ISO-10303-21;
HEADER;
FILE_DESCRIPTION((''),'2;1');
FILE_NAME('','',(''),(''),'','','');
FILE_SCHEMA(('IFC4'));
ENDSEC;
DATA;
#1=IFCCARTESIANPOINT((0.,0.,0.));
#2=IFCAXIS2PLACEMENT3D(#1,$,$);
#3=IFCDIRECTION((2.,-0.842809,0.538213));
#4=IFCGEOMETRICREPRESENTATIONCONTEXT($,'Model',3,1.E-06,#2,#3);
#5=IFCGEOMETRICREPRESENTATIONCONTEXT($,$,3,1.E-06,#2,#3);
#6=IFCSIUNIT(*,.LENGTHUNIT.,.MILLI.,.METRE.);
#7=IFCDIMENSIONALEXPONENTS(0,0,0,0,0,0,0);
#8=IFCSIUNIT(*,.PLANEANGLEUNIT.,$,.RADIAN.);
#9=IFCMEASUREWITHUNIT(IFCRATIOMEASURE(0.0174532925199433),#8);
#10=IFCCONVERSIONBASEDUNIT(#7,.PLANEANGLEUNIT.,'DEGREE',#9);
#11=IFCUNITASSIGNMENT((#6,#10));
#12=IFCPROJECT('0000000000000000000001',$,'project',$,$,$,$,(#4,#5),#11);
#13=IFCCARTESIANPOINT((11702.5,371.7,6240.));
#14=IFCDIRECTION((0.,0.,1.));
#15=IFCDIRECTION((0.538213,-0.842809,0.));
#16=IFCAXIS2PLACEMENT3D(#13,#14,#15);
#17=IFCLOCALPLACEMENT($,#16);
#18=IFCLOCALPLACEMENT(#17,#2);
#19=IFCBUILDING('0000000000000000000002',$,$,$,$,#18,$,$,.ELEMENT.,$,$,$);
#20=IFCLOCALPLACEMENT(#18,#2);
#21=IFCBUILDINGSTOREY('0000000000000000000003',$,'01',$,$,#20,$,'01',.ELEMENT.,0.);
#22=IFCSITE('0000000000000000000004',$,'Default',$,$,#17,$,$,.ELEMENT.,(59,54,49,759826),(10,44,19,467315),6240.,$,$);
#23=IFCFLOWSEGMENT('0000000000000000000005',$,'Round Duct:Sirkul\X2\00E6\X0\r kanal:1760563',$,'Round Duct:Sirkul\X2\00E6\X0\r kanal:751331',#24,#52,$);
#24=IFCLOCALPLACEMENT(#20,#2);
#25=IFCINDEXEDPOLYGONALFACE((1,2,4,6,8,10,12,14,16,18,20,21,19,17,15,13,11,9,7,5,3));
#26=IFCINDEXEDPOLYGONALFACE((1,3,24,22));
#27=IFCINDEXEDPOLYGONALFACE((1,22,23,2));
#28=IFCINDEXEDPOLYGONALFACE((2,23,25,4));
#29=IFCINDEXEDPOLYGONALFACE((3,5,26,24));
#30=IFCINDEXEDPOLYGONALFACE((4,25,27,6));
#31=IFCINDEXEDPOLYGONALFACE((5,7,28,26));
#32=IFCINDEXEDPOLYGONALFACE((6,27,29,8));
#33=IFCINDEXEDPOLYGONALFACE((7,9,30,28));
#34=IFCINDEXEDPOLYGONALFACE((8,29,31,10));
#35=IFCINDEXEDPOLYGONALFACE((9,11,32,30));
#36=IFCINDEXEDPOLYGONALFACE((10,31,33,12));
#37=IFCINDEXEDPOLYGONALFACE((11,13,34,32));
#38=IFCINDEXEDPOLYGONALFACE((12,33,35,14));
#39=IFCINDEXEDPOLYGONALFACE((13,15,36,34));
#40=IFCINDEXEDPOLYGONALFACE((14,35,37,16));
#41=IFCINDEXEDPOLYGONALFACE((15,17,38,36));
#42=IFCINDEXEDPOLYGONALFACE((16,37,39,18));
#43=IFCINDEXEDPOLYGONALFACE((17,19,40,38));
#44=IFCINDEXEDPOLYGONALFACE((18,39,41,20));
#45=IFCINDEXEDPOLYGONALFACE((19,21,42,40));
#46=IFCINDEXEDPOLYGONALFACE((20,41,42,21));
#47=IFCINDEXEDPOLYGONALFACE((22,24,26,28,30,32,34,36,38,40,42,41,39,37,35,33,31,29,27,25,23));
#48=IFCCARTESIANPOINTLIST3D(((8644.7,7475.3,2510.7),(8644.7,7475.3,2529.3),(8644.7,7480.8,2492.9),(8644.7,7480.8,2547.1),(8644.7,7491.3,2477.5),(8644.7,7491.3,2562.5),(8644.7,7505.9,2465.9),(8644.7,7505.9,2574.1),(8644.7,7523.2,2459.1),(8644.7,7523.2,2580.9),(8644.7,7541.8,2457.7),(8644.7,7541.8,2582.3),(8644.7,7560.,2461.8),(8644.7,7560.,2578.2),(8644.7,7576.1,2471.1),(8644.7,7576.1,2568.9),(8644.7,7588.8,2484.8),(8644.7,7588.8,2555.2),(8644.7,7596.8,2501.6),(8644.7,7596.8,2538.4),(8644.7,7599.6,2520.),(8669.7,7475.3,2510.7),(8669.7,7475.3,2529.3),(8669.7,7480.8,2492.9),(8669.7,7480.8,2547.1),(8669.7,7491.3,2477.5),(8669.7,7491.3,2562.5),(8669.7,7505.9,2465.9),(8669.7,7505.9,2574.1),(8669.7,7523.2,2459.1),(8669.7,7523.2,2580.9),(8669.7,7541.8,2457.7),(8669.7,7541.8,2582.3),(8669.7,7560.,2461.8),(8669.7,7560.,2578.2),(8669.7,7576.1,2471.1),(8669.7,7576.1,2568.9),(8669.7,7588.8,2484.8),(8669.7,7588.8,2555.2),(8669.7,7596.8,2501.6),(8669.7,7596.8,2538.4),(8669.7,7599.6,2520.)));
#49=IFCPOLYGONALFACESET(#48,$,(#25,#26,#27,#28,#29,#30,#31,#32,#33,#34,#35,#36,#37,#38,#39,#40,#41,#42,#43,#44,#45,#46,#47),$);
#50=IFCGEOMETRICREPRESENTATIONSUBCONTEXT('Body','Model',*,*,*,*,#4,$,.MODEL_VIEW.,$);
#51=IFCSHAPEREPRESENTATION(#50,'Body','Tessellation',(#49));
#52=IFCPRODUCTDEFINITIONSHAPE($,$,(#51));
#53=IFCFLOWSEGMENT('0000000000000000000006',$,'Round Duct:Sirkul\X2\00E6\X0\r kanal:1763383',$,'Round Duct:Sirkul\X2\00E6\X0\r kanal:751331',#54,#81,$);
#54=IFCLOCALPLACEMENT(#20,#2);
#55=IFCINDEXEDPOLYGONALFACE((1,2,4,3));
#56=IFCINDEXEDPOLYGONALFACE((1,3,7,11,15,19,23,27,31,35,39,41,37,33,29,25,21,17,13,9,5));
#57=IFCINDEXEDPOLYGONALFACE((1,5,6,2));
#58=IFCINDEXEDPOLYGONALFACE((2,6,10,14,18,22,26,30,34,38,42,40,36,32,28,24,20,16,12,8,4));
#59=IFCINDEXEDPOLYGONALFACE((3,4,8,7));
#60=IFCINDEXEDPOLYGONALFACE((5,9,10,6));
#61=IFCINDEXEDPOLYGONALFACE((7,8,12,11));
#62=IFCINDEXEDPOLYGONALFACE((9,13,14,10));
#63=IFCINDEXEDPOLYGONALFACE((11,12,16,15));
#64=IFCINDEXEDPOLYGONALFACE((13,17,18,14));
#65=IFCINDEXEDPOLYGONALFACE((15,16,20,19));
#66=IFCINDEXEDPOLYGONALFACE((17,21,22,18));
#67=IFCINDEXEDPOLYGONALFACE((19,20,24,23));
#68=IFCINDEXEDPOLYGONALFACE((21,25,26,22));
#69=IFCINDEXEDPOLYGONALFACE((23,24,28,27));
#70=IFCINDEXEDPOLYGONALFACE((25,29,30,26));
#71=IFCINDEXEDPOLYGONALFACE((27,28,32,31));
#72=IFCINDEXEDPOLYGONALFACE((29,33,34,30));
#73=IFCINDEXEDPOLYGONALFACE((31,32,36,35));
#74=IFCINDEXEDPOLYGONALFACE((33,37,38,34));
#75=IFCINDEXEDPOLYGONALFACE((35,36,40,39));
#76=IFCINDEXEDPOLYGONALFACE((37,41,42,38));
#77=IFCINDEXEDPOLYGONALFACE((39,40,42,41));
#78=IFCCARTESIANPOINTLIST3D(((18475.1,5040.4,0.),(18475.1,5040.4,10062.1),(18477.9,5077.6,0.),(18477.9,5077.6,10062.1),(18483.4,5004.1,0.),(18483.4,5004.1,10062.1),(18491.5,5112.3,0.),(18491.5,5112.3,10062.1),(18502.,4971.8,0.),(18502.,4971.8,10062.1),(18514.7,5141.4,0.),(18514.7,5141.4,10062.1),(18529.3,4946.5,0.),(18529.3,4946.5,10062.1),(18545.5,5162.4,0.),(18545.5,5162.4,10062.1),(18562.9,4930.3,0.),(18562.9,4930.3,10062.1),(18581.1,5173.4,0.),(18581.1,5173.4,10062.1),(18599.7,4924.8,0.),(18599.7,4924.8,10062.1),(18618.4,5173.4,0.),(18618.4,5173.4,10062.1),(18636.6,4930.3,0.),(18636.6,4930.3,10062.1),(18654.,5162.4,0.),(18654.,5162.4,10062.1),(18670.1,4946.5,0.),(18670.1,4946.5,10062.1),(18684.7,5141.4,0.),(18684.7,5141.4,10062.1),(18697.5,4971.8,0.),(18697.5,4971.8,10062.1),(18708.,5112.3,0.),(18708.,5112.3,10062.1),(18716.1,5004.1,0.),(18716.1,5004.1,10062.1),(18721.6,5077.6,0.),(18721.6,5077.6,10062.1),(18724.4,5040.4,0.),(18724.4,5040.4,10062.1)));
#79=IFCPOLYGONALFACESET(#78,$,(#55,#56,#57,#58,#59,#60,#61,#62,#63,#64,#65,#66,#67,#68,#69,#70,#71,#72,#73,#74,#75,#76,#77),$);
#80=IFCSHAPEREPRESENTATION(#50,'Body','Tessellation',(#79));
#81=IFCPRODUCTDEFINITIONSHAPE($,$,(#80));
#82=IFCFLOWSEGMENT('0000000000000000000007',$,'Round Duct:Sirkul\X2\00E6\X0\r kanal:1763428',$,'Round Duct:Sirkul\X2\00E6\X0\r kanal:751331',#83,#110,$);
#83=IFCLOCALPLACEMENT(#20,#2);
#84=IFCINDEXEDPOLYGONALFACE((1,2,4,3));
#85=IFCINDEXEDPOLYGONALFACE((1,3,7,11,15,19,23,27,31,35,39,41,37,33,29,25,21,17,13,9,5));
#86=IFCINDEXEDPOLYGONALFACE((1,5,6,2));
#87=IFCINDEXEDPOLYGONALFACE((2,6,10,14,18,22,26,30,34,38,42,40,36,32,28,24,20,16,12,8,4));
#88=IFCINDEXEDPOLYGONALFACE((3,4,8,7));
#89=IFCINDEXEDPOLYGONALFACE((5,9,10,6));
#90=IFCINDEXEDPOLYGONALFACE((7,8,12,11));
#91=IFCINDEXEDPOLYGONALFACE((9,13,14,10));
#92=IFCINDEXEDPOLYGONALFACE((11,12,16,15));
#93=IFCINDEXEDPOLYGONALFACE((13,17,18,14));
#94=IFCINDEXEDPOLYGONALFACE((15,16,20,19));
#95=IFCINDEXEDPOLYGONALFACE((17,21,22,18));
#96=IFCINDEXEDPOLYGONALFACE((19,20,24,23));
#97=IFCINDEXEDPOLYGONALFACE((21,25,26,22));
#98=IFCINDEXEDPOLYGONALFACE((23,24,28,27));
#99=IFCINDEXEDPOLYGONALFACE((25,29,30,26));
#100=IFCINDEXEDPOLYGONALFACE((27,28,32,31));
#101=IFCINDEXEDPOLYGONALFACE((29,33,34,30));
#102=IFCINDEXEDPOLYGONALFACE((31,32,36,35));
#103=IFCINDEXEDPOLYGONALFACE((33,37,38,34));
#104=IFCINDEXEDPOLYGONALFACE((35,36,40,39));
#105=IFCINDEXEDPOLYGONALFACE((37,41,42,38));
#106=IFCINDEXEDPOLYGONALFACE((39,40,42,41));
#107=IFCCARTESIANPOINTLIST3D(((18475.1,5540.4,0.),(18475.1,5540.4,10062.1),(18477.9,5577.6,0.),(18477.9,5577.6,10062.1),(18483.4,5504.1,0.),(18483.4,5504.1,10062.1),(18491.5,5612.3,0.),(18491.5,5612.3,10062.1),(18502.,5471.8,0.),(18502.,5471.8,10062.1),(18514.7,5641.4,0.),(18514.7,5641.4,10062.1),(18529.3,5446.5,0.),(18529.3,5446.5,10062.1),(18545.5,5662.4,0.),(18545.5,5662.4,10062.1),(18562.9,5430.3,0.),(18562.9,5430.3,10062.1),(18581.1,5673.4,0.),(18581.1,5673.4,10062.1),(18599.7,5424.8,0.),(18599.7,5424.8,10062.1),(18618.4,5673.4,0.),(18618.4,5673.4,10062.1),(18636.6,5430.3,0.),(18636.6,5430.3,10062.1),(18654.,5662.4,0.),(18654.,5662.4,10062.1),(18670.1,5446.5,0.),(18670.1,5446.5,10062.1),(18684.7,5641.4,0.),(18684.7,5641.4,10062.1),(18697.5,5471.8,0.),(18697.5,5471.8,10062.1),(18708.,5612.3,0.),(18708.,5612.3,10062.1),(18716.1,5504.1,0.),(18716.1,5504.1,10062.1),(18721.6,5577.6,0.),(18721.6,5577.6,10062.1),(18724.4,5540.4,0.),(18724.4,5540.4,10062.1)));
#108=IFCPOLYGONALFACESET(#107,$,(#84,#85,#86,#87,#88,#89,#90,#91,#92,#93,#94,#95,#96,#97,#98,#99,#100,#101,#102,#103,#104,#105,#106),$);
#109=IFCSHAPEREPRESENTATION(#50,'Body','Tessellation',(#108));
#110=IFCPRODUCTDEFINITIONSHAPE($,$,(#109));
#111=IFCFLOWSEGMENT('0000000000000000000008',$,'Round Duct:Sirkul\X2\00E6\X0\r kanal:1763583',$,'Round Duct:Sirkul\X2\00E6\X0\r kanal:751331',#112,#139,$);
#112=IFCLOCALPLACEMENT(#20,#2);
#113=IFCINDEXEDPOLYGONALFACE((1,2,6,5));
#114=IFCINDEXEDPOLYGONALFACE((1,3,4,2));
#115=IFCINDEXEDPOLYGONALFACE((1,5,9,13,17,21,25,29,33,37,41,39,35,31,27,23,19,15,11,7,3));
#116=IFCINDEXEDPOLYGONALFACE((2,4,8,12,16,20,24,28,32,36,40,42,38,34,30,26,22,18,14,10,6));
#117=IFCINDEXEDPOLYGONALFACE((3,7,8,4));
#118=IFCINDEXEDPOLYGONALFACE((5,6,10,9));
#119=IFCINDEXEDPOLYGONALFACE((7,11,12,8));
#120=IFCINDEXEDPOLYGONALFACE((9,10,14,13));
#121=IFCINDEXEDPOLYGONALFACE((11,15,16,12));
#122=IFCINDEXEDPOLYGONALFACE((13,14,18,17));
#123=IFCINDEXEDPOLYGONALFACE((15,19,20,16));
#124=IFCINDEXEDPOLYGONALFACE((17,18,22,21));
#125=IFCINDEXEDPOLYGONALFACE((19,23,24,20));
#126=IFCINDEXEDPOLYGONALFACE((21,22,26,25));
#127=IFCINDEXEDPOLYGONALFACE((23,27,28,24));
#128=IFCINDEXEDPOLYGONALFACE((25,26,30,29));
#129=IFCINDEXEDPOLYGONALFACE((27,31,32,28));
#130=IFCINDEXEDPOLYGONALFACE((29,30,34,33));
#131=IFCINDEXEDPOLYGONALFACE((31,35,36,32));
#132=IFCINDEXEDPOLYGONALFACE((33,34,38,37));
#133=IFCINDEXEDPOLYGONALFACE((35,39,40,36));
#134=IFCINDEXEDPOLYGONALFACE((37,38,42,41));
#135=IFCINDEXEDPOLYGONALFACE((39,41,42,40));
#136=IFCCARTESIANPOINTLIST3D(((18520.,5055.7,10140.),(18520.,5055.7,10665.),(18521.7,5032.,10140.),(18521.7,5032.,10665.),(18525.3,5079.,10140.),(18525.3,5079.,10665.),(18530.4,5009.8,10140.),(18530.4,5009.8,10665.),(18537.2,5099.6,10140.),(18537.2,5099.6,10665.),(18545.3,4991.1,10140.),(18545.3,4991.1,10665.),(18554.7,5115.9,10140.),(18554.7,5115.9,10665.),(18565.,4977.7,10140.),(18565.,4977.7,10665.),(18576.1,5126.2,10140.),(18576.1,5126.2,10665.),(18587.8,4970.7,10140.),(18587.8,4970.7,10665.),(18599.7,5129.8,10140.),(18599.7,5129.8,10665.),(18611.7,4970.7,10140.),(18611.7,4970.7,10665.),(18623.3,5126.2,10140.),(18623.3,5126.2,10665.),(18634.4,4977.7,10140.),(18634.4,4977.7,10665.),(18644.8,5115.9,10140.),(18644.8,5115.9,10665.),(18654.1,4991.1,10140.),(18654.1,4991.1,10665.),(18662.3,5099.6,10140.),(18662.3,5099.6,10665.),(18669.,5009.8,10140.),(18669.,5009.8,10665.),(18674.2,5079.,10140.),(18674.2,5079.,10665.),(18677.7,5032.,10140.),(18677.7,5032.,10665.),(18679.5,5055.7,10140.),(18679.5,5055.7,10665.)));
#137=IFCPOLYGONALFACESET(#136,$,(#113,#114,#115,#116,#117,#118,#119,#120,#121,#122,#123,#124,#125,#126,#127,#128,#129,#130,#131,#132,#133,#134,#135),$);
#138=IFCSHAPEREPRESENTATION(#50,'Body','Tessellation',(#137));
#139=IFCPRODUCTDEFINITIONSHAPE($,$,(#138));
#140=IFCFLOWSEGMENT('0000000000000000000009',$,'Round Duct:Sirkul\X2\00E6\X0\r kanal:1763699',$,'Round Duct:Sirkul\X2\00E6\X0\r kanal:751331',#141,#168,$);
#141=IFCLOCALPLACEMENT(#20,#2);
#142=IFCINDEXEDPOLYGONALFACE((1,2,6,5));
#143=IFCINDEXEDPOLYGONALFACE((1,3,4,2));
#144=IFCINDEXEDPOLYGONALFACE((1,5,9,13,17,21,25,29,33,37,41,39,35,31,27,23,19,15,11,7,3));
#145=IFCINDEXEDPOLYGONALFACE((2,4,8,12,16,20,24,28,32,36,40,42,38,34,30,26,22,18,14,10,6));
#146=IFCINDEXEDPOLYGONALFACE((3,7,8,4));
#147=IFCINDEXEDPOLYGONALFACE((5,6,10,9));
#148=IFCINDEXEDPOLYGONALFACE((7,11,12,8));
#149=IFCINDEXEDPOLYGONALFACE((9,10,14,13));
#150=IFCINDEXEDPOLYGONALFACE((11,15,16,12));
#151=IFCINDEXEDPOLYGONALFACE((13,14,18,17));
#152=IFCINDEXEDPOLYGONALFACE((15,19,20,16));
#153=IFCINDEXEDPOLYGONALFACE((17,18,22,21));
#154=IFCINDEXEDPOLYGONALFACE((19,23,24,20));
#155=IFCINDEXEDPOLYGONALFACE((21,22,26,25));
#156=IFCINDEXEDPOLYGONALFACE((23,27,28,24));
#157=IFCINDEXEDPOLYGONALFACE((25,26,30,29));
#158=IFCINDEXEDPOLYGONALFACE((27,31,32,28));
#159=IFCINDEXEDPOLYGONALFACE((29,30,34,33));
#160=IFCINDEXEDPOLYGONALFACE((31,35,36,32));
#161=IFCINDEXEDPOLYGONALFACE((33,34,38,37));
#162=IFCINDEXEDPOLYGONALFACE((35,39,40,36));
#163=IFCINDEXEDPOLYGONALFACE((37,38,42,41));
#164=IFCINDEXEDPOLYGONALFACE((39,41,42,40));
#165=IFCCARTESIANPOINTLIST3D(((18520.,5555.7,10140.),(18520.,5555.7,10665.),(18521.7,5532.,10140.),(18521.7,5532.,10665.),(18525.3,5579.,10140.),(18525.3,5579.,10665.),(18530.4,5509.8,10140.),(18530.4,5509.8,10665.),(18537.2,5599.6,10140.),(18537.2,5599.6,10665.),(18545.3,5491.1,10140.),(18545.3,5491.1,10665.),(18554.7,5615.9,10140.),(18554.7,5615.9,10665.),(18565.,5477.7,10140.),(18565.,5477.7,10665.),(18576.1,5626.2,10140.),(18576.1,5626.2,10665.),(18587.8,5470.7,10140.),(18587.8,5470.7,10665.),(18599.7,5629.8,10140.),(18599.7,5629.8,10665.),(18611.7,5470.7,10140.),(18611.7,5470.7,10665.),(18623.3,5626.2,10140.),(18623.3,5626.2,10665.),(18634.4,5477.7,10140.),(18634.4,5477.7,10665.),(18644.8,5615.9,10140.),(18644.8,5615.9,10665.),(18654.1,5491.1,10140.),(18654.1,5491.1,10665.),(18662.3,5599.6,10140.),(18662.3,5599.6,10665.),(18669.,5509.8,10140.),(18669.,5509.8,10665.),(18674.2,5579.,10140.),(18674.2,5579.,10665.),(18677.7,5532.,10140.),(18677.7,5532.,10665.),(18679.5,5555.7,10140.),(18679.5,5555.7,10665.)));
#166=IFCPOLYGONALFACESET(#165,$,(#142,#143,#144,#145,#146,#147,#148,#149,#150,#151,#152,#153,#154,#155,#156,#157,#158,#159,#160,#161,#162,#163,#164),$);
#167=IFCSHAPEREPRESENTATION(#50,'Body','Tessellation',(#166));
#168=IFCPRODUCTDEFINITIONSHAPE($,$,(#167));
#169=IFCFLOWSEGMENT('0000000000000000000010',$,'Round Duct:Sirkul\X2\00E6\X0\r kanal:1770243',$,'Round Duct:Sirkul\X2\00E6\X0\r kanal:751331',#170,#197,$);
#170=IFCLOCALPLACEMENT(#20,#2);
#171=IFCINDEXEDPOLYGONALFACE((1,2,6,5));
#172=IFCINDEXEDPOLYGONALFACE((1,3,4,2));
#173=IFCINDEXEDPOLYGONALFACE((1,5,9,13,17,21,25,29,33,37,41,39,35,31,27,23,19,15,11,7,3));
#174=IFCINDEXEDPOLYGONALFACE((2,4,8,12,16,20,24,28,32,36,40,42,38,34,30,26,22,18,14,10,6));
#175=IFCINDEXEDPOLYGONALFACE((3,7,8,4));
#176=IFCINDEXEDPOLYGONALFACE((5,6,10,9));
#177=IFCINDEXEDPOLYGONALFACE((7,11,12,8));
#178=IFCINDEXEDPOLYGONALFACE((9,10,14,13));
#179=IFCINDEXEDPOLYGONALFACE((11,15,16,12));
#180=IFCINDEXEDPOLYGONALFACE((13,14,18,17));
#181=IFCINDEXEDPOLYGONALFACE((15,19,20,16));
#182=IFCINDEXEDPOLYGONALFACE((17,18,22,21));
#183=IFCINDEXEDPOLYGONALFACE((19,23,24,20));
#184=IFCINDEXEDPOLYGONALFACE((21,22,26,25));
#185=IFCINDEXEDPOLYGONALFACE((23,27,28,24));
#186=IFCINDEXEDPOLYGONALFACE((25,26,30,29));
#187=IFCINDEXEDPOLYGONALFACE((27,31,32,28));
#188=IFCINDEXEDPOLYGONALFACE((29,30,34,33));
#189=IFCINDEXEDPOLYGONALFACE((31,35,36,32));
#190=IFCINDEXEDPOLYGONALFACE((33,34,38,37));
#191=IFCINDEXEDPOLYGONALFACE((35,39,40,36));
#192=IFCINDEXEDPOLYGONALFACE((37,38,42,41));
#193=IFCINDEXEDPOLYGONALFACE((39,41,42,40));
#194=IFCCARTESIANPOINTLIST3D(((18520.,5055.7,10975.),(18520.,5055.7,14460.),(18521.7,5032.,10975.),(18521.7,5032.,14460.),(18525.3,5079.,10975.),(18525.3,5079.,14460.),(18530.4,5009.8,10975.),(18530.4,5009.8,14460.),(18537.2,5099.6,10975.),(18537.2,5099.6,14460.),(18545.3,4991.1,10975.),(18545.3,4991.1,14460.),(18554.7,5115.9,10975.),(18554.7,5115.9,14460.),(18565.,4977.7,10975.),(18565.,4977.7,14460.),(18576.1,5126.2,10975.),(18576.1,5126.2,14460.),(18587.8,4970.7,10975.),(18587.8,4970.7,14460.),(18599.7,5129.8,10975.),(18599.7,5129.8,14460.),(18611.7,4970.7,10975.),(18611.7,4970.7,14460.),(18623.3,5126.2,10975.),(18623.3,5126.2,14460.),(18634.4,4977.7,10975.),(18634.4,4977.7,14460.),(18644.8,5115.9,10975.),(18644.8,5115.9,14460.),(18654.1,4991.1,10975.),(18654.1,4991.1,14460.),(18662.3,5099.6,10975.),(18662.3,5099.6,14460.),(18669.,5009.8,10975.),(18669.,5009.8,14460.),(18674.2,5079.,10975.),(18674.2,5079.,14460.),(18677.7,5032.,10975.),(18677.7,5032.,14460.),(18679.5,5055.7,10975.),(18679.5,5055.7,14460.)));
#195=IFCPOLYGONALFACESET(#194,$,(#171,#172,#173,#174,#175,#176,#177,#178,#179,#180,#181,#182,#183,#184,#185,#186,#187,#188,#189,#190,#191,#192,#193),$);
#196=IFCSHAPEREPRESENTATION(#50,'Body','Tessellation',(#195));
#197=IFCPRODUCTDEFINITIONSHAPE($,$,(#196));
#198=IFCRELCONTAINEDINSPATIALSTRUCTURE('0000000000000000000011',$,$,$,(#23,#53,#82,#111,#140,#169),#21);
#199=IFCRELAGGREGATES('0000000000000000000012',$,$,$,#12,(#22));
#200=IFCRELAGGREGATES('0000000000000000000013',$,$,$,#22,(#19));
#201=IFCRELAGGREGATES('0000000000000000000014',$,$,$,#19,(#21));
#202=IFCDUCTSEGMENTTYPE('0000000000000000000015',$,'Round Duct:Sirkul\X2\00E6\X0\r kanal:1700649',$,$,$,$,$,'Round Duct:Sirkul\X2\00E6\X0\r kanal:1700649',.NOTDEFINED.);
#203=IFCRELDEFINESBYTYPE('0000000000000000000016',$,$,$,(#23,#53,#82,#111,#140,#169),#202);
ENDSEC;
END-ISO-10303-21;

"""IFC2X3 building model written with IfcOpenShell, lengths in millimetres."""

from ifc_helpers import new_model, entity, si_unit, converted_unit, direction, frame, frame_2d, origin, origin_2d_with_axis, place, context, subcontext, project, spatial, circle, extrude, type_object, element, save


model = new_model("IFC2X3")

# Units and contexts
model_context = context("Model", 3, precision=1e-06, world=origin(), true_north=direction((2.0, -0.842809, 0.538213)))
context_of_model = context(None, 3, precision=1e-06, world=origin(), true_north=direction((2.0, -0.842809, 0.538213)))
body_context = subcontext(model_context, "Body", "Model", "MODEL_VIEW")
ifc_project = project(units=[si_unit("LENGTHUNIT", "METRE", prefix="MILLI"), converted_unit("PLANEANGLEUNIT", "DEGREE", entity("IfcRatioMeasure", 0.0174532925199433), si_unit("PLANEANGLEUNIT", "RADIAN"), dimensions=[0, 0, 0, 0, 0, 0, 0])], contexts=[model_context, context_of_model])

# Site, building, storey
site_placement = place(None, frame((11702.5, 371.7, 6240.0), z_axis=(0.0, 0.0, 1.0), x_axis=(0.538213, -0.842809, 0.0)))
site = spatial("IfcSite", under=ifc_project, at=site_placement, Name="Default", CompositionType="ELEMENT", RefLatitude=(59, 54, 49, 759826), RefLongitude=(10, 44, 19, 467315), RefElevation=6240.0)
building_placement = place(site_placement, origin())
building = spatial("IfcBuilding", under=site, at=building_placement, CompositionType="ELEMENT")
storey_placement = place(building_placement, origin())
storey = spatial("IfcBuildingStorey", under=building, at=storey_placement, Name="01", LongName="01", CompositionType="ELEMENT", Elevation=0.0)

# Flow segments
duct_segment_type_1 = type_object("IfcDuctSegmentType", Name="Round Duct:Sirkulær kanal:1700649", ElementType="Round Duct:Sirkulær kanal:1700649", PredefinedType="NOTDEFINED")
flow_segment_1_placement = place(storey_placement, origin())
element("IfcFlowSegment", 1, at=flow_segment_1_placement, inside=storey, type_object=duct_segment_type_1, Name="Round Duct:Sirkulær kanal:1760563", ObjectType="Round Duct:Sirkulær kanal:751331", context=body_context, shape_type="SweptSolid", body=[
    extrude(circle(Radius=62.5, at=frame_2d((0.0, 0.0), x_axis=(1.0, 0.0))), frame((8644.7, 7537.1, 2520.0), z_axis=(1.0, 0.0, 0.0), x_axis=(0.0, 1.0, 0.0)), (0.0, 0.0, 1.0), 25.0),
])
flow_segment_2_placement = place(storey_placement, origin())
element("IfcFlowSegment", 2, at=flow_segment_2_placement, inside=storey, type_object=duct_segment_type_1, Name="Round Duct:Sirkulær kanal:1763383", ObjectType="Round Duct:Sirkulær kanal:751331", context=body_context, shape_type="SweptSolid", body=[
    extrude(circle(Radius=125.0, at=frame_2d((0.0, 0.0), x_axis=(1.0, 0.0))), frame((18599.7, 5049.8, 0.0), z_axis=(0.0, 0.0, 1.0), x_axis=(0.0, -1.0, 0.0)), (0.0, 0.0, 1.0), 10062.1),
])
flow_segment_3_placement = place(storey_placement, origin())
element("IfcFlowSegment", 3, at=flow_segment_3_placement, inside=storey, type_object=duct_segment_type_1, Name="Round Duct:Sirkulær kanal:1763428", ObjectType="Round Duct:Sirkulær kanal:751331", context=body_context, shape_type="SweptSolid", body=[
    extrude(circle(Radius=125.0, at=frame_2d((0.0, 0.0), x_axis=(1.0, 0.0))), frame((18599.7, 5549.8, 0.0), z_axis=(0.0, 0.0, 1.0), x_axis=(0.0, -1.0, 0.0)), (0.0, 0.0, 1.0), 10062.1),
])
flow_segment_4_placement = place(storey_placement, origin())
element("IfcFlowSegment", 4, at=flow_segment_4_placement, inside=storey, type_object=duct_segment_type_1, Name="Round Duct:Sirkulær kanal:1763583", ObjectType="Round Duct:Sirkulær kanal:751331", context=body_context, shape_type="SweptSolid", body=[
    extrude(circle(Radius=80.0, at=origin_2d_with_axis()), frame((18599.7, 5049.8, 10140.0), z_axis=(0.0, 0.0, 1.0), x_axis=(0.0, 1.0, 0.0)), (0.0, 0.0, 1.0), 525.0),
])
flow_segment_5_placement = place(storey_placement, origin())
element("IfcFlowSegment", 5, at=flow_segment_5_placement, inside=storey, type_object=duct_segment_type_1, Name="Round Duct:Sirkulær kanal:1763699", ObjectType="Round Duct:Sirkulær kanal:751331", context=body_context, shape_type="SweptSolid", body=[
    extrude(circle(Radius=80.0, at=origin_2d_with_axis()), frame((18599.7, 5549.8, 10140.0), z_axis=(0.0, 0.0, 1.0), x_axis=(0.0, 1.0, 0.0)), (0.0, 0.0, 1.0), 525.0),
])
flow_segment_6_placement = place(storey_placement, origin())
element("IfcFlowSegment", 6, at=flow_segment_6_placement, inside=storey, type_object=duct_segment_type_1, Name="Round Duct:Sirkulær kanal:1770243", ObjectType="Round Duct:Sirkulær kanal:751331", context=body_context, shape_type="SweptSolid", body=[
    extrude(circle(Radius=80.0, at=origin_2d_with_axis()), frame((18599.7, 5049.8, 10975.0), z_axis=(0.0, 0.0, 1.0), x_axis=(0.0, 1.0, 0.0)), (0.0, 0.0, 1.0), 3485.0),
])

save(model, "model.ifc")
